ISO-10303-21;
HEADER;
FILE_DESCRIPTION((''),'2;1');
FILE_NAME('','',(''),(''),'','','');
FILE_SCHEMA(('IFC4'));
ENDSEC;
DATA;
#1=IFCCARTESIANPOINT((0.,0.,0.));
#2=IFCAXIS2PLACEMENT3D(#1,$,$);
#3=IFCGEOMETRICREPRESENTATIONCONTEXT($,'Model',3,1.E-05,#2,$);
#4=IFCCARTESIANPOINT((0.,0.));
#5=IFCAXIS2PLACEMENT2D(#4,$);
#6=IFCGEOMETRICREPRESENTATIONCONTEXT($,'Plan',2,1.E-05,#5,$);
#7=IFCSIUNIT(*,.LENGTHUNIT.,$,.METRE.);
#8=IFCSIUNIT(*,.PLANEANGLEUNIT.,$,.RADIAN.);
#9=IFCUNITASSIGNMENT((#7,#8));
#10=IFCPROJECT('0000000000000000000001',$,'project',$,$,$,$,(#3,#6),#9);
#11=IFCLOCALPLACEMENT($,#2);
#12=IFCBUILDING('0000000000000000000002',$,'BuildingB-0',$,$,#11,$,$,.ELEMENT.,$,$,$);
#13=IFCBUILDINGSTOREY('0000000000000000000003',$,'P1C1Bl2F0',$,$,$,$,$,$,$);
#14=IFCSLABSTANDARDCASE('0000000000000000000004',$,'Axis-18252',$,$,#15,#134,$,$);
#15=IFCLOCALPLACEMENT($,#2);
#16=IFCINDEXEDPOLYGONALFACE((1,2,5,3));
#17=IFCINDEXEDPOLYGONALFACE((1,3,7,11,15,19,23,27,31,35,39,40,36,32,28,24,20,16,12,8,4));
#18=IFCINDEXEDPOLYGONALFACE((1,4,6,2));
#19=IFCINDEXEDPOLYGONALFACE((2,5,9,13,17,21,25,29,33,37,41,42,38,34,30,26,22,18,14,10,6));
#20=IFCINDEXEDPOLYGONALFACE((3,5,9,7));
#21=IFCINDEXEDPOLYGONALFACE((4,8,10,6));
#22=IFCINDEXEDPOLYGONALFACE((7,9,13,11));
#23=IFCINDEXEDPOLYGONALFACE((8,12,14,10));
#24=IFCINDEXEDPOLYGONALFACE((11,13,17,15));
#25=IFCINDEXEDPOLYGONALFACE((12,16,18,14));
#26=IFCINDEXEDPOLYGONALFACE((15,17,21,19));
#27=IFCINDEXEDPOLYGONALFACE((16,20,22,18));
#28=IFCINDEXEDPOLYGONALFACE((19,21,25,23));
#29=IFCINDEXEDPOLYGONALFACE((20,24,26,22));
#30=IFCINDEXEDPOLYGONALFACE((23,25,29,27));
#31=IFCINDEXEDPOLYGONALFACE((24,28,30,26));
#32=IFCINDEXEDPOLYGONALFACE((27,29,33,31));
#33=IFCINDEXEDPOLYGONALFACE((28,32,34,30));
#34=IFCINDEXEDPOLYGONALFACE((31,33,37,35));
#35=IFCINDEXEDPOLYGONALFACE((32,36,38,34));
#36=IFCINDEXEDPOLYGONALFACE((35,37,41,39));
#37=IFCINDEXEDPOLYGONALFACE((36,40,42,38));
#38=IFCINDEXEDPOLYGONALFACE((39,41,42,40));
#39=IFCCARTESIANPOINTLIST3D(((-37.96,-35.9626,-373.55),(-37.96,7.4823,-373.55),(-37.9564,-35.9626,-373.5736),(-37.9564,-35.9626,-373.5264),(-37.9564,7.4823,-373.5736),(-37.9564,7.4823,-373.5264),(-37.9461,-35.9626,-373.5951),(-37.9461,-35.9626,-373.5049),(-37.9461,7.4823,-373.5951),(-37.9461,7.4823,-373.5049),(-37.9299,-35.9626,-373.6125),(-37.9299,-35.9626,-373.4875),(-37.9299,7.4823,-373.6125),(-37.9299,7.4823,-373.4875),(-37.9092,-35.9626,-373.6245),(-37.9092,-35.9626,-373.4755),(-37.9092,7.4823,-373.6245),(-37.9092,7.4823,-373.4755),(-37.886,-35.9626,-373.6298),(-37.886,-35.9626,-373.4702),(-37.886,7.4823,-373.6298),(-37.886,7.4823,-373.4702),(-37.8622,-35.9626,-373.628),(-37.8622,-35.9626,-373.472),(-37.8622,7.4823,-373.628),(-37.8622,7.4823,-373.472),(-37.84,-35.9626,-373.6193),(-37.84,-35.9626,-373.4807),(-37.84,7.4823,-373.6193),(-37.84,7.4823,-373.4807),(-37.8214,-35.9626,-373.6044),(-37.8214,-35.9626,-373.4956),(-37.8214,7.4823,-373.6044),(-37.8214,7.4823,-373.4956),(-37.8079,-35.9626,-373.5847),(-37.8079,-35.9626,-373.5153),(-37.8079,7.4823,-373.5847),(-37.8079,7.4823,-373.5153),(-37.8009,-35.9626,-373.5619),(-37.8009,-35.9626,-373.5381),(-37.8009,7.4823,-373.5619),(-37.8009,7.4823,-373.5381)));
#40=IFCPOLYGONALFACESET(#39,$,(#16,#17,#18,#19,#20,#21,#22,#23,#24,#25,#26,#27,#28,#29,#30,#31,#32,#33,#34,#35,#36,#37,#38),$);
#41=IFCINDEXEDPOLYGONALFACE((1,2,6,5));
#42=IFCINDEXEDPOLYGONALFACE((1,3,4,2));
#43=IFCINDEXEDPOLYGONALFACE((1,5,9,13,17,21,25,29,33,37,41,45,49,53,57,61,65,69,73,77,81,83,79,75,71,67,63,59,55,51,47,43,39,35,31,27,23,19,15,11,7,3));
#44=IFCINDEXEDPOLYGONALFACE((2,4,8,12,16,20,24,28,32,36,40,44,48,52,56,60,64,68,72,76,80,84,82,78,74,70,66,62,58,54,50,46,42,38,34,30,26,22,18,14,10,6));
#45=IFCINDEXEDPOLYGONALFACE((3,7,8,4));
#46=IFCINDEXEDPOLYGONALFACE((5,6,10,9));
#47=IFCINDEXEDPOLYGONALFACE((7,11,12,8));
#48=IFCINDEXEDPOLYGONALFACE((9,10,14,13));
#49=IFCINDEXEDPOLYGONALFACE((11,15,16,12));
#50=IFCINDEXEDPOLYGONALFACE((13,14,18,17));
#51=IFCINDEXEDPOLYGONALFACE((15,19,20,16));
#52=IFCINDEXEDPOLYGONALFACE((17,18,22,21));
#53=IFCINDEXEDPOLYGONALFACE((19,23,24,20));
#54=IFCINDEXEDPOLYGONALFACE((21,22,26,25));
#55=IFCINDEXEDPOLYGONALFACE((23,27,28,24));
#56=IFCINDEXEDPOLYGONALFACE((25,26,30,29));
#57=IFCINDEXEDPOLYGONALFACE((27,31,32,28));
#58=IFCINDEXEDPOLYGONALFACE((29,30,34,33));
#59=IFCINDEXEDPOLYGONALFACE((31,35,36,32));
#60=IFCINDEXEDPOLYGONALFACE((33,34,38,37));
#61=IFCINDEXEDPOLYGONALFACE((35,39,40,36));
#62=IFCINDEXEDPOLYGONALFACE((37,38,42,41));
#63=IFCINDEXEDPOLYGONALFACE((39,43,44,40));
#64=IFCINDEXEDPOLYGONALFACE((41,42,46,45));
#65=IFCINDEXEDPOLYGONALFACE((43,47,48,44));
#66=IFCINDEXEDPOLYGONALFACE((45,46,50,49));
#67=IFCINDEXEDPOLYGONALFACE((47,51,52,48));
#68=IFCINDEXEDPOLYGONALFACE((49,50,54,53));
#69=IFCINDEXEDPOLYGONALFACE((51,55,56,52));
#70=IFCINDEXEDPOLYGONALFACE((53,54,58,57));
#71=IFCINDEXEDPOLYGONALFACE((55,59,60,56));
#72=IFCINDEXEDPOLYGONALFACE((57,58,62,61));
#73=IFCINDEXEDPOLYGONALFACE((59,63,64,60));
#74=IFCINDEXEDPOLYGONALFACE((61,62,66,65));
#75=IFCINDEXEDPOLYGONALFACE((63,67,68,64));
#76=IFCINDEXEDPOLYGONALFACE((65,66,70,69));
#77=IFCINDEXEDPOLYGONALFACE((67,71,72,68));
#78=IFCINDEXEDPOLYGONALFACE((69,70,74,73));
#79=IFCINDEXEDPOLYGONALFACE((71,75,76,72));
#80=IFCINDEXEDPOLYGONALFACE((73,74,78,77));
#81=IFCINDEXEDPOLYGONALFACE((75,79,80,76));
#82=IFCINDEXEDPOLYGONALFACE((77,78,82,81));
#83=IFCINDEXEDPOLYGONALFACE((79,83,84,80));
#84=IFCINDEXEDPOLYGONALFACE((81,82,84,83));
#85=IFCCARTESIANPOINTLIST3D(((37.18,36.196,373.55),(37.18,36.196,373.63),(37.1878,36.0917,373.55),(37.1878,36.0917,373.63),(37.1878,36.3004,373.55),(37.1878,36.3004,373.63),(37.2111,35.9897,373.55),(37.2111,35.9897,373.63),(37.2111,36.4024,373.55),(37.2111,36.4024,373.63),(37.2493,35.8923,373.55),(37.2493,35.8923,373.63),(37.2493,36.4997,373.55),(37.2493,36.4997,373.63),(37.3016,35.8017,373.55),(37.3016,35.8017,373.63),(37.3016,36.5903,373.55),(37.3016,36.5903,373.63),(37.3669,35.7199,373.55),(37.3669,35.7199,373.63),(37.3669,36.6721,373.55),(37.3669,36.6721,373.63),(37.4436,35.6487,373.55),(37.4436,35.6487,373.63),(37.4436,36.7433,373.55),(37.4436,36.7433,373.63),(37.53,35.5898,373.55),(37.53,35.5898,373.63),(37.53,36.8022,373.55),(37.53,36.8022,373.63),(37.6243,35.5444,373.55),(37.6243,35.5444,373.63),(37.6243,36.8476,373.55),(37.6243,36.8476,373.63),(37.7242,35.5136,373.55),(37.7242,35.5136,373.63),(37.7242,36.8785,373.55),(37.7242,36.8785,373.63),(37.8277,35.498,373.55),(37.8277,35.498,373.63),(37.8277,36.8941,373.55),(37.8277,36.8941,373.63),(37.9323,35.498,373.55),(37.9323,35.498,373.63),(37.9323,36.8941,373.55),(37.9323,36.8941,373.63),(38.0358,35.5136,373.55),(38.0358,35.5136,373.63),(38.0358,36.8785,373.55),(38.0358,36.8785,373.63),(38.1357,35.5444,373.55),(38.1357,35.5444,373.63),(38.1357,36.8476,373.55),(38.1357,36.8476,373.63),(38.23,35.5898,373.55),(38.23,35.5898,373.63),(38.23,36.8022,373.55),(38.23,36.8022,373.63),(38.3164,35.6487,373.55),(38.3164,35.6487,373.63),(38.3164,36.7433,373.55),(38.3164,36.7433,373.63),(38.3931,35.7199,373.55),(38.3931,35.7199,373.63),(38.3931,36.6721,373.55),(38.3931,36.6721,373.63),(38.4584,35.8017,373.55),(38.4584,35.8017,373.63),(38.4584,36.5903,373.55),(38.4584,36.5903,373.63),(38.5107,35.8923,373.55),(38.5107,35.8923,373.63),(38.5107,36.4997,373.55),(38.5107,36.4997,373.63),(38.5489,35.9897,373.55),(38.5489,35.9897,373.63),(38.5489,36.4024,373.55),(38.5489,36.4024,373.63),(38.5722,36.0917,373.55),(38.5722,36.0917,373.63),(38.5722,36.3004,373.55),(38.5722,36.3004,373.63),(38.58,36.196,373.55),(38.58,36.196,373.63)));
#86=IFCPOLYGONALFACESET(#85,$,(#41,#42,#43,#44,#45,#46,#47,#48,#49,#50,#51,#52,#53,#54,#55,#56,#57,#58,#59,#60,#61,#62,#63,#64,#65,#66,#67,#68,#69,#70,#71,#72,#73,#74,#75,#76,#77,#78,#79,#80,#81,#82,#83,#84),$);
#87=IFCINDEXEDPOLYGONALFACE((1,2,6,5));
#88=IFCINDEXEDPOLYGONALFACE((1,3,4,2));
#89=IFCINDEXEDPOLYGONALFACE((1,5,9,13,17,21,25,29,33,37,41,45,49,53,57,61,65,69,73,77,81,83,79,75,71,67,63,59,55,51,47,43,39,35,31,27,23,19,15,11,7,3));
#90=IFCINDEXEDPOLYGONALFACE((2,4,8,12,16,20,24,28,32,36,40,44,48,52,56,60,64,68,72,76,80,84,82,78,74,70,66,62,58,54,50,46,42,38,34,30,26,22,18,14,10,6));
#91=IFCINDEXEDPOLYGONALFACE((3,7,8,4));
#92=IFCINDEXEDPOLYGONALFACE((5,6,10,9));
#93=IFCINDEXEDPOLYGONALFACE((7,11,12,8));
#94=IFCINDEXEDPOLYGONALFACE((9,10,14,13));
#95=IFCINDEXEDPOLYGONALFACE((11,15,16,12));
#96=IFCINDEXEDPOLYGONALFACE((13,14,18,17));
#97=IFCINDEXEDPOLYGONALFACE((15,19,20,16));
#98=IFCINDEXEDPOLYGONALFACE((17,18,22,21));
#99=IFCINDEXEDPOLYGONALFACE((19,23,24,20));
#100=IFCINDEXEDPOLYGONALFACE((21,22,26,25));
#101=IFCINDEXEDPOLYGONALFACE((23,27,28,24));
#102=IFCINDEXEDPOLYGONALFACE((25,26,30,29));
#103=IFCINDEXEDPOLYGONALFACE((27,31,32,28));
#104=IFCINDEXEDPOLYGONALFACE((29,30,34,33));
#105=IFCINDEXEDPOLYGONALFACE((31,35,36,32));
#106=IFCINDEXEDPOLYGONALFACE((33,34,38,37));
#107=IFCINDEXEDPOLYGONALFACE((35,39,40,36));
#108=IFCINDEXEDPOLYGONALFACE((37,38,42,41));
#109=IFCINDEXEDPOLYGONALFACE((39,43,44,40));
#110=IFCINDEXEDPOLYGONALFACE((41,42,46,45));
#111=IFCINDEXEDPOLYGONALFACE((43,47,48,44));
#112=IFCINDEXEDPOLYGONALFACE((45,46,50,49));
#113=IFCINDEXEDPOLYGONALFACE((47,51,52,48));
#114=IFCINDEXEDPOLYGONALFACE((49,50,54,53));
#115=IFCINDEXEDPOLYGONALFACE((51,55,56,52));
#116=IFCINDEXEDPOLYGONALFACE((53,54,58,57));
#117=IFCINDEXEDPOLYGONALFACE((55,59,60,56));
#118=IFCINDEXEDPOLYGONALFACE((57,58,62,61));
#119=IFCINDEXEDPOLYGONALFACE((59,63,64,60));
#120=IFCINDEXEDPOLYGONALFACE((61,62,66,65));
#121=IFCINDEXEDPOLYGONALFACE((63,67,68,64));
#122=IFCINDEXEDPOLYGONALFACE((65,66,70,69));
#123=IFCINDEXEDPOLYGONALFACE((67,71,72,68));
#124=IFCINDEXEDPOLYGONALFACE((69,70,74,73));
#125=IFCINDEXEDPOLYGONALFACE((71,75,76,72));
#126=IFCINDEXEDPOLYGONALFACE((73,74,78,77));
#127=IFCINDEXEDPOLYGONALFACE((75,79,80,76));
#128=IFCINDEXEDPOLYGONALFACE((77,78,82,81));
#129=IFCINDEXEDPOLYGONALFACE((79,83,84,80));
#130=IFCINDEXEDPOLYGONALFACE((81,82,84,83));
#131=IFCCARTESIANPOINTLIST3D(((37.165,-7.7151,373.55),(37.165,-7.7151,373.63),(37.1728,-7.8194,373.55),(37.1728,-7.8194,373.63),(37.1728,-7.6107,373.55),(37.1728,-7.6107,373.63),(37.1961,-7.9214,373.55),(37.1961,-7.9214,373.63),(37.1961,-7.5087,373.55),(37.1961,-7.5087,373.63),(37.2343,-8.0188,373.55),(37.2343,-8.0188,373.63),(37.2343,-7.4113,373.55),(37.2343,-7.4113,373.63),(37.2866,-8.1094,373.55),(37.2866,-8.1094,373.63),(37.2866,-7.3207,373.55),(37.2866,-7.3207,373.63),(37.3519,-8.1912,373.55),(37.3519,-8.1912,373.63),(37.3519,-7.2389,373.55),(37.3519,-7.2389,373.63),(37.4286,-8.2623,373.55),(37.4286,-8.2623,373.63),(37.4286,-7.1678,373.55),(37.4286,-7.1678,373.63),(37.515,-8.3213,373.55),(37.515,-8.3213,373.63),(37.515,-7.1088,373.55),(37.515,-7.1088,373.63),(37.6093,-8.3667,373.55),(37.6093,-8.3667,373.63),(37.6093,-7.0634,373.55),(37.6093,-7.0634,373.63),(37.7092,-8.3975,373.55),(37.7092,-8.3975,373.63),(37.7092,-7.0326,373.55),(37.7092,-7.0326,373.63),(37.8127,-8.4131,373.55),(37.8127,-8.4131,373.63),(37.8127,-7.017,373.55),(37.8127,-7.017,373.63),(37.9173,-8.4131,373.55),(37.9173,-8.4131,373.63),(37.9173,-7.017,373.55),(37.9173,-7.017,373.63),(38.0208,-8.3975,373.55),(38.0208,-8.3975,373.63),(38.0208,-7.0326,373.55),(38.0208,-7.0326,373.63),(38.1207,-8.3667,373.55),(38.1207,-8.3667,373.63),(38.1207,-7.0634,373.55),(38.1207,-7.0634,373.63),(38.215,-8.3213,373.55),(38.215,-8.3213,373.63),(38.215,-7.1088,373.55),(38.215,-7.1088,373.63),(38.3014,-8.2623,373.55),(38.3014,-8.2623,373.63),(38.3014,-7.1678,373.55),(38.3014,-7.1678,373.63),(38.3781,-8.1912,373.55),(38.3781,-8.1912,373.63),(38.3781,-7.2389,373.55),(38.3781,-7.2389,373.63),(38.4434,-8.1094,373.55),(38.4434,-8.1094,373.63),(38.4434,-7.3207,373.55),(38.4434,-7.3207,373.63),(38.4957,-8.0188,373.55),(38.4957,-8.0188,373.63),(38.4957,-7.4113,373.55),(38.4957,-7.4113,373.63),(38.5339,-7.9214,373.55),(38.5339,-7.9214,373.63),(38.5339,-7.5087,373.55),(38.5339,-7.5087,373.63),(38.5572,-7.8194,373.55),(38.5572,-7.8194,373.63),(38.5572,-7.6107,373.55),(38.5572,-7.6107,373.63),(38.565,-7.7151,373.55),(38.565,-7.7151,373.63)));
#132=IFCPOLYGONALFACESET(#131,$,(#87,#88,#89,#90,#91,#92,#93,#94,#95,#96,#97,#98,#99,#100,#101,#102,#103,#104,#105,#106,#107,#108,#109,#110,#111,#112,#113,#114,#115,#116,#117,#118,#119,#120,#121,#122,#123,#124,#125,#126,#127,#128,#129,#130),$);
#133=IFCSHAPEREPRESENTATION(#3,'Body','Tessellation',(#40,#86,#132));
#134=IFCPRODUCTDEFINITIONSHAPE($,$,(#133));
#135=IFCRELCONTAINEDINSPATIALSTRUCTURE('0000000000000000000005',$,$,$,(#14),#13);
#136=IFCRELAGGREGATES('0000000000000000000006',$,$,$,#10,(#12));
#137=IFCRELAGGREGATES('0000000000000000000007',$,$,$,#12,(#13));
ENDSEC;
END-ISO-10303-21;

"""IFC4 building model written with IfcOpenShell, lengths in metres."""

from ifc_helpers import new_model, entity, si_unit, frame, origin, origin_2d, place, context, project, spatial, circle, extrude, element, save


model = new_model("IFC4")

# Units and contexts
model_context = context("Model", 3, precision=1e-05, world=origin())
plan_context = context("Plan", 2, precision=1e-05, world=origin_2d())
ifc_project = project(units=[si_unit("LENGTHUNIT", "METRE"), si_unit("PLANEANGLEUNIT", "RADIAN")], contexts=[model_context, plan_context])

# Building, storey
building_placement = place(None, origin())
building = spatial("IfcBuilding", under=ifc_project, at=building_placement, Name="BuildingB-0", CompositionType="ELEMENT")
storey = spatial("IfcBuildingStorey", under=building, Name="P1C1Bl2F0")

# Slab
element("IfcSlabStandardCase", 1, inside=storey, Name="Axis-18252", context=model_context, shape_type="AdvancedSweptSolid", body=[
    entity("IfcSurfaceCurveSweptAreaSolid", entity("IfcCircleProfileDef", "AREA", None, None, 0.08), None, entity("IfcPolyline", [entity("IfcCartesianPoint", [37.88, 35.9626, 373.55]), entity("IfcCartesianPoint", [37.88, -7.4823, 373.55])]), None, None, entity("IfcPlane", entity("IfcAxis2Placement3D", entity("IfcCartesianPoint", [37.88, 35.9626, 373.55]), entity("IfcDirection", [0.0, 0.0, 1.0]), entity("IfcDirection", [1.0, 0.0, 0.0])))),
    extrude(circle(Radius=0.7), frame((37.88, 36.196, 373.55)), (0.0, 0.0, 1.0), 0.08),
    extrude(circle(Radius=0.7), frame((37.865, -7.7151, 373.55)), (0.0, 0.0, 1.0), 0.08),
])

save(model, "model.ifc")
